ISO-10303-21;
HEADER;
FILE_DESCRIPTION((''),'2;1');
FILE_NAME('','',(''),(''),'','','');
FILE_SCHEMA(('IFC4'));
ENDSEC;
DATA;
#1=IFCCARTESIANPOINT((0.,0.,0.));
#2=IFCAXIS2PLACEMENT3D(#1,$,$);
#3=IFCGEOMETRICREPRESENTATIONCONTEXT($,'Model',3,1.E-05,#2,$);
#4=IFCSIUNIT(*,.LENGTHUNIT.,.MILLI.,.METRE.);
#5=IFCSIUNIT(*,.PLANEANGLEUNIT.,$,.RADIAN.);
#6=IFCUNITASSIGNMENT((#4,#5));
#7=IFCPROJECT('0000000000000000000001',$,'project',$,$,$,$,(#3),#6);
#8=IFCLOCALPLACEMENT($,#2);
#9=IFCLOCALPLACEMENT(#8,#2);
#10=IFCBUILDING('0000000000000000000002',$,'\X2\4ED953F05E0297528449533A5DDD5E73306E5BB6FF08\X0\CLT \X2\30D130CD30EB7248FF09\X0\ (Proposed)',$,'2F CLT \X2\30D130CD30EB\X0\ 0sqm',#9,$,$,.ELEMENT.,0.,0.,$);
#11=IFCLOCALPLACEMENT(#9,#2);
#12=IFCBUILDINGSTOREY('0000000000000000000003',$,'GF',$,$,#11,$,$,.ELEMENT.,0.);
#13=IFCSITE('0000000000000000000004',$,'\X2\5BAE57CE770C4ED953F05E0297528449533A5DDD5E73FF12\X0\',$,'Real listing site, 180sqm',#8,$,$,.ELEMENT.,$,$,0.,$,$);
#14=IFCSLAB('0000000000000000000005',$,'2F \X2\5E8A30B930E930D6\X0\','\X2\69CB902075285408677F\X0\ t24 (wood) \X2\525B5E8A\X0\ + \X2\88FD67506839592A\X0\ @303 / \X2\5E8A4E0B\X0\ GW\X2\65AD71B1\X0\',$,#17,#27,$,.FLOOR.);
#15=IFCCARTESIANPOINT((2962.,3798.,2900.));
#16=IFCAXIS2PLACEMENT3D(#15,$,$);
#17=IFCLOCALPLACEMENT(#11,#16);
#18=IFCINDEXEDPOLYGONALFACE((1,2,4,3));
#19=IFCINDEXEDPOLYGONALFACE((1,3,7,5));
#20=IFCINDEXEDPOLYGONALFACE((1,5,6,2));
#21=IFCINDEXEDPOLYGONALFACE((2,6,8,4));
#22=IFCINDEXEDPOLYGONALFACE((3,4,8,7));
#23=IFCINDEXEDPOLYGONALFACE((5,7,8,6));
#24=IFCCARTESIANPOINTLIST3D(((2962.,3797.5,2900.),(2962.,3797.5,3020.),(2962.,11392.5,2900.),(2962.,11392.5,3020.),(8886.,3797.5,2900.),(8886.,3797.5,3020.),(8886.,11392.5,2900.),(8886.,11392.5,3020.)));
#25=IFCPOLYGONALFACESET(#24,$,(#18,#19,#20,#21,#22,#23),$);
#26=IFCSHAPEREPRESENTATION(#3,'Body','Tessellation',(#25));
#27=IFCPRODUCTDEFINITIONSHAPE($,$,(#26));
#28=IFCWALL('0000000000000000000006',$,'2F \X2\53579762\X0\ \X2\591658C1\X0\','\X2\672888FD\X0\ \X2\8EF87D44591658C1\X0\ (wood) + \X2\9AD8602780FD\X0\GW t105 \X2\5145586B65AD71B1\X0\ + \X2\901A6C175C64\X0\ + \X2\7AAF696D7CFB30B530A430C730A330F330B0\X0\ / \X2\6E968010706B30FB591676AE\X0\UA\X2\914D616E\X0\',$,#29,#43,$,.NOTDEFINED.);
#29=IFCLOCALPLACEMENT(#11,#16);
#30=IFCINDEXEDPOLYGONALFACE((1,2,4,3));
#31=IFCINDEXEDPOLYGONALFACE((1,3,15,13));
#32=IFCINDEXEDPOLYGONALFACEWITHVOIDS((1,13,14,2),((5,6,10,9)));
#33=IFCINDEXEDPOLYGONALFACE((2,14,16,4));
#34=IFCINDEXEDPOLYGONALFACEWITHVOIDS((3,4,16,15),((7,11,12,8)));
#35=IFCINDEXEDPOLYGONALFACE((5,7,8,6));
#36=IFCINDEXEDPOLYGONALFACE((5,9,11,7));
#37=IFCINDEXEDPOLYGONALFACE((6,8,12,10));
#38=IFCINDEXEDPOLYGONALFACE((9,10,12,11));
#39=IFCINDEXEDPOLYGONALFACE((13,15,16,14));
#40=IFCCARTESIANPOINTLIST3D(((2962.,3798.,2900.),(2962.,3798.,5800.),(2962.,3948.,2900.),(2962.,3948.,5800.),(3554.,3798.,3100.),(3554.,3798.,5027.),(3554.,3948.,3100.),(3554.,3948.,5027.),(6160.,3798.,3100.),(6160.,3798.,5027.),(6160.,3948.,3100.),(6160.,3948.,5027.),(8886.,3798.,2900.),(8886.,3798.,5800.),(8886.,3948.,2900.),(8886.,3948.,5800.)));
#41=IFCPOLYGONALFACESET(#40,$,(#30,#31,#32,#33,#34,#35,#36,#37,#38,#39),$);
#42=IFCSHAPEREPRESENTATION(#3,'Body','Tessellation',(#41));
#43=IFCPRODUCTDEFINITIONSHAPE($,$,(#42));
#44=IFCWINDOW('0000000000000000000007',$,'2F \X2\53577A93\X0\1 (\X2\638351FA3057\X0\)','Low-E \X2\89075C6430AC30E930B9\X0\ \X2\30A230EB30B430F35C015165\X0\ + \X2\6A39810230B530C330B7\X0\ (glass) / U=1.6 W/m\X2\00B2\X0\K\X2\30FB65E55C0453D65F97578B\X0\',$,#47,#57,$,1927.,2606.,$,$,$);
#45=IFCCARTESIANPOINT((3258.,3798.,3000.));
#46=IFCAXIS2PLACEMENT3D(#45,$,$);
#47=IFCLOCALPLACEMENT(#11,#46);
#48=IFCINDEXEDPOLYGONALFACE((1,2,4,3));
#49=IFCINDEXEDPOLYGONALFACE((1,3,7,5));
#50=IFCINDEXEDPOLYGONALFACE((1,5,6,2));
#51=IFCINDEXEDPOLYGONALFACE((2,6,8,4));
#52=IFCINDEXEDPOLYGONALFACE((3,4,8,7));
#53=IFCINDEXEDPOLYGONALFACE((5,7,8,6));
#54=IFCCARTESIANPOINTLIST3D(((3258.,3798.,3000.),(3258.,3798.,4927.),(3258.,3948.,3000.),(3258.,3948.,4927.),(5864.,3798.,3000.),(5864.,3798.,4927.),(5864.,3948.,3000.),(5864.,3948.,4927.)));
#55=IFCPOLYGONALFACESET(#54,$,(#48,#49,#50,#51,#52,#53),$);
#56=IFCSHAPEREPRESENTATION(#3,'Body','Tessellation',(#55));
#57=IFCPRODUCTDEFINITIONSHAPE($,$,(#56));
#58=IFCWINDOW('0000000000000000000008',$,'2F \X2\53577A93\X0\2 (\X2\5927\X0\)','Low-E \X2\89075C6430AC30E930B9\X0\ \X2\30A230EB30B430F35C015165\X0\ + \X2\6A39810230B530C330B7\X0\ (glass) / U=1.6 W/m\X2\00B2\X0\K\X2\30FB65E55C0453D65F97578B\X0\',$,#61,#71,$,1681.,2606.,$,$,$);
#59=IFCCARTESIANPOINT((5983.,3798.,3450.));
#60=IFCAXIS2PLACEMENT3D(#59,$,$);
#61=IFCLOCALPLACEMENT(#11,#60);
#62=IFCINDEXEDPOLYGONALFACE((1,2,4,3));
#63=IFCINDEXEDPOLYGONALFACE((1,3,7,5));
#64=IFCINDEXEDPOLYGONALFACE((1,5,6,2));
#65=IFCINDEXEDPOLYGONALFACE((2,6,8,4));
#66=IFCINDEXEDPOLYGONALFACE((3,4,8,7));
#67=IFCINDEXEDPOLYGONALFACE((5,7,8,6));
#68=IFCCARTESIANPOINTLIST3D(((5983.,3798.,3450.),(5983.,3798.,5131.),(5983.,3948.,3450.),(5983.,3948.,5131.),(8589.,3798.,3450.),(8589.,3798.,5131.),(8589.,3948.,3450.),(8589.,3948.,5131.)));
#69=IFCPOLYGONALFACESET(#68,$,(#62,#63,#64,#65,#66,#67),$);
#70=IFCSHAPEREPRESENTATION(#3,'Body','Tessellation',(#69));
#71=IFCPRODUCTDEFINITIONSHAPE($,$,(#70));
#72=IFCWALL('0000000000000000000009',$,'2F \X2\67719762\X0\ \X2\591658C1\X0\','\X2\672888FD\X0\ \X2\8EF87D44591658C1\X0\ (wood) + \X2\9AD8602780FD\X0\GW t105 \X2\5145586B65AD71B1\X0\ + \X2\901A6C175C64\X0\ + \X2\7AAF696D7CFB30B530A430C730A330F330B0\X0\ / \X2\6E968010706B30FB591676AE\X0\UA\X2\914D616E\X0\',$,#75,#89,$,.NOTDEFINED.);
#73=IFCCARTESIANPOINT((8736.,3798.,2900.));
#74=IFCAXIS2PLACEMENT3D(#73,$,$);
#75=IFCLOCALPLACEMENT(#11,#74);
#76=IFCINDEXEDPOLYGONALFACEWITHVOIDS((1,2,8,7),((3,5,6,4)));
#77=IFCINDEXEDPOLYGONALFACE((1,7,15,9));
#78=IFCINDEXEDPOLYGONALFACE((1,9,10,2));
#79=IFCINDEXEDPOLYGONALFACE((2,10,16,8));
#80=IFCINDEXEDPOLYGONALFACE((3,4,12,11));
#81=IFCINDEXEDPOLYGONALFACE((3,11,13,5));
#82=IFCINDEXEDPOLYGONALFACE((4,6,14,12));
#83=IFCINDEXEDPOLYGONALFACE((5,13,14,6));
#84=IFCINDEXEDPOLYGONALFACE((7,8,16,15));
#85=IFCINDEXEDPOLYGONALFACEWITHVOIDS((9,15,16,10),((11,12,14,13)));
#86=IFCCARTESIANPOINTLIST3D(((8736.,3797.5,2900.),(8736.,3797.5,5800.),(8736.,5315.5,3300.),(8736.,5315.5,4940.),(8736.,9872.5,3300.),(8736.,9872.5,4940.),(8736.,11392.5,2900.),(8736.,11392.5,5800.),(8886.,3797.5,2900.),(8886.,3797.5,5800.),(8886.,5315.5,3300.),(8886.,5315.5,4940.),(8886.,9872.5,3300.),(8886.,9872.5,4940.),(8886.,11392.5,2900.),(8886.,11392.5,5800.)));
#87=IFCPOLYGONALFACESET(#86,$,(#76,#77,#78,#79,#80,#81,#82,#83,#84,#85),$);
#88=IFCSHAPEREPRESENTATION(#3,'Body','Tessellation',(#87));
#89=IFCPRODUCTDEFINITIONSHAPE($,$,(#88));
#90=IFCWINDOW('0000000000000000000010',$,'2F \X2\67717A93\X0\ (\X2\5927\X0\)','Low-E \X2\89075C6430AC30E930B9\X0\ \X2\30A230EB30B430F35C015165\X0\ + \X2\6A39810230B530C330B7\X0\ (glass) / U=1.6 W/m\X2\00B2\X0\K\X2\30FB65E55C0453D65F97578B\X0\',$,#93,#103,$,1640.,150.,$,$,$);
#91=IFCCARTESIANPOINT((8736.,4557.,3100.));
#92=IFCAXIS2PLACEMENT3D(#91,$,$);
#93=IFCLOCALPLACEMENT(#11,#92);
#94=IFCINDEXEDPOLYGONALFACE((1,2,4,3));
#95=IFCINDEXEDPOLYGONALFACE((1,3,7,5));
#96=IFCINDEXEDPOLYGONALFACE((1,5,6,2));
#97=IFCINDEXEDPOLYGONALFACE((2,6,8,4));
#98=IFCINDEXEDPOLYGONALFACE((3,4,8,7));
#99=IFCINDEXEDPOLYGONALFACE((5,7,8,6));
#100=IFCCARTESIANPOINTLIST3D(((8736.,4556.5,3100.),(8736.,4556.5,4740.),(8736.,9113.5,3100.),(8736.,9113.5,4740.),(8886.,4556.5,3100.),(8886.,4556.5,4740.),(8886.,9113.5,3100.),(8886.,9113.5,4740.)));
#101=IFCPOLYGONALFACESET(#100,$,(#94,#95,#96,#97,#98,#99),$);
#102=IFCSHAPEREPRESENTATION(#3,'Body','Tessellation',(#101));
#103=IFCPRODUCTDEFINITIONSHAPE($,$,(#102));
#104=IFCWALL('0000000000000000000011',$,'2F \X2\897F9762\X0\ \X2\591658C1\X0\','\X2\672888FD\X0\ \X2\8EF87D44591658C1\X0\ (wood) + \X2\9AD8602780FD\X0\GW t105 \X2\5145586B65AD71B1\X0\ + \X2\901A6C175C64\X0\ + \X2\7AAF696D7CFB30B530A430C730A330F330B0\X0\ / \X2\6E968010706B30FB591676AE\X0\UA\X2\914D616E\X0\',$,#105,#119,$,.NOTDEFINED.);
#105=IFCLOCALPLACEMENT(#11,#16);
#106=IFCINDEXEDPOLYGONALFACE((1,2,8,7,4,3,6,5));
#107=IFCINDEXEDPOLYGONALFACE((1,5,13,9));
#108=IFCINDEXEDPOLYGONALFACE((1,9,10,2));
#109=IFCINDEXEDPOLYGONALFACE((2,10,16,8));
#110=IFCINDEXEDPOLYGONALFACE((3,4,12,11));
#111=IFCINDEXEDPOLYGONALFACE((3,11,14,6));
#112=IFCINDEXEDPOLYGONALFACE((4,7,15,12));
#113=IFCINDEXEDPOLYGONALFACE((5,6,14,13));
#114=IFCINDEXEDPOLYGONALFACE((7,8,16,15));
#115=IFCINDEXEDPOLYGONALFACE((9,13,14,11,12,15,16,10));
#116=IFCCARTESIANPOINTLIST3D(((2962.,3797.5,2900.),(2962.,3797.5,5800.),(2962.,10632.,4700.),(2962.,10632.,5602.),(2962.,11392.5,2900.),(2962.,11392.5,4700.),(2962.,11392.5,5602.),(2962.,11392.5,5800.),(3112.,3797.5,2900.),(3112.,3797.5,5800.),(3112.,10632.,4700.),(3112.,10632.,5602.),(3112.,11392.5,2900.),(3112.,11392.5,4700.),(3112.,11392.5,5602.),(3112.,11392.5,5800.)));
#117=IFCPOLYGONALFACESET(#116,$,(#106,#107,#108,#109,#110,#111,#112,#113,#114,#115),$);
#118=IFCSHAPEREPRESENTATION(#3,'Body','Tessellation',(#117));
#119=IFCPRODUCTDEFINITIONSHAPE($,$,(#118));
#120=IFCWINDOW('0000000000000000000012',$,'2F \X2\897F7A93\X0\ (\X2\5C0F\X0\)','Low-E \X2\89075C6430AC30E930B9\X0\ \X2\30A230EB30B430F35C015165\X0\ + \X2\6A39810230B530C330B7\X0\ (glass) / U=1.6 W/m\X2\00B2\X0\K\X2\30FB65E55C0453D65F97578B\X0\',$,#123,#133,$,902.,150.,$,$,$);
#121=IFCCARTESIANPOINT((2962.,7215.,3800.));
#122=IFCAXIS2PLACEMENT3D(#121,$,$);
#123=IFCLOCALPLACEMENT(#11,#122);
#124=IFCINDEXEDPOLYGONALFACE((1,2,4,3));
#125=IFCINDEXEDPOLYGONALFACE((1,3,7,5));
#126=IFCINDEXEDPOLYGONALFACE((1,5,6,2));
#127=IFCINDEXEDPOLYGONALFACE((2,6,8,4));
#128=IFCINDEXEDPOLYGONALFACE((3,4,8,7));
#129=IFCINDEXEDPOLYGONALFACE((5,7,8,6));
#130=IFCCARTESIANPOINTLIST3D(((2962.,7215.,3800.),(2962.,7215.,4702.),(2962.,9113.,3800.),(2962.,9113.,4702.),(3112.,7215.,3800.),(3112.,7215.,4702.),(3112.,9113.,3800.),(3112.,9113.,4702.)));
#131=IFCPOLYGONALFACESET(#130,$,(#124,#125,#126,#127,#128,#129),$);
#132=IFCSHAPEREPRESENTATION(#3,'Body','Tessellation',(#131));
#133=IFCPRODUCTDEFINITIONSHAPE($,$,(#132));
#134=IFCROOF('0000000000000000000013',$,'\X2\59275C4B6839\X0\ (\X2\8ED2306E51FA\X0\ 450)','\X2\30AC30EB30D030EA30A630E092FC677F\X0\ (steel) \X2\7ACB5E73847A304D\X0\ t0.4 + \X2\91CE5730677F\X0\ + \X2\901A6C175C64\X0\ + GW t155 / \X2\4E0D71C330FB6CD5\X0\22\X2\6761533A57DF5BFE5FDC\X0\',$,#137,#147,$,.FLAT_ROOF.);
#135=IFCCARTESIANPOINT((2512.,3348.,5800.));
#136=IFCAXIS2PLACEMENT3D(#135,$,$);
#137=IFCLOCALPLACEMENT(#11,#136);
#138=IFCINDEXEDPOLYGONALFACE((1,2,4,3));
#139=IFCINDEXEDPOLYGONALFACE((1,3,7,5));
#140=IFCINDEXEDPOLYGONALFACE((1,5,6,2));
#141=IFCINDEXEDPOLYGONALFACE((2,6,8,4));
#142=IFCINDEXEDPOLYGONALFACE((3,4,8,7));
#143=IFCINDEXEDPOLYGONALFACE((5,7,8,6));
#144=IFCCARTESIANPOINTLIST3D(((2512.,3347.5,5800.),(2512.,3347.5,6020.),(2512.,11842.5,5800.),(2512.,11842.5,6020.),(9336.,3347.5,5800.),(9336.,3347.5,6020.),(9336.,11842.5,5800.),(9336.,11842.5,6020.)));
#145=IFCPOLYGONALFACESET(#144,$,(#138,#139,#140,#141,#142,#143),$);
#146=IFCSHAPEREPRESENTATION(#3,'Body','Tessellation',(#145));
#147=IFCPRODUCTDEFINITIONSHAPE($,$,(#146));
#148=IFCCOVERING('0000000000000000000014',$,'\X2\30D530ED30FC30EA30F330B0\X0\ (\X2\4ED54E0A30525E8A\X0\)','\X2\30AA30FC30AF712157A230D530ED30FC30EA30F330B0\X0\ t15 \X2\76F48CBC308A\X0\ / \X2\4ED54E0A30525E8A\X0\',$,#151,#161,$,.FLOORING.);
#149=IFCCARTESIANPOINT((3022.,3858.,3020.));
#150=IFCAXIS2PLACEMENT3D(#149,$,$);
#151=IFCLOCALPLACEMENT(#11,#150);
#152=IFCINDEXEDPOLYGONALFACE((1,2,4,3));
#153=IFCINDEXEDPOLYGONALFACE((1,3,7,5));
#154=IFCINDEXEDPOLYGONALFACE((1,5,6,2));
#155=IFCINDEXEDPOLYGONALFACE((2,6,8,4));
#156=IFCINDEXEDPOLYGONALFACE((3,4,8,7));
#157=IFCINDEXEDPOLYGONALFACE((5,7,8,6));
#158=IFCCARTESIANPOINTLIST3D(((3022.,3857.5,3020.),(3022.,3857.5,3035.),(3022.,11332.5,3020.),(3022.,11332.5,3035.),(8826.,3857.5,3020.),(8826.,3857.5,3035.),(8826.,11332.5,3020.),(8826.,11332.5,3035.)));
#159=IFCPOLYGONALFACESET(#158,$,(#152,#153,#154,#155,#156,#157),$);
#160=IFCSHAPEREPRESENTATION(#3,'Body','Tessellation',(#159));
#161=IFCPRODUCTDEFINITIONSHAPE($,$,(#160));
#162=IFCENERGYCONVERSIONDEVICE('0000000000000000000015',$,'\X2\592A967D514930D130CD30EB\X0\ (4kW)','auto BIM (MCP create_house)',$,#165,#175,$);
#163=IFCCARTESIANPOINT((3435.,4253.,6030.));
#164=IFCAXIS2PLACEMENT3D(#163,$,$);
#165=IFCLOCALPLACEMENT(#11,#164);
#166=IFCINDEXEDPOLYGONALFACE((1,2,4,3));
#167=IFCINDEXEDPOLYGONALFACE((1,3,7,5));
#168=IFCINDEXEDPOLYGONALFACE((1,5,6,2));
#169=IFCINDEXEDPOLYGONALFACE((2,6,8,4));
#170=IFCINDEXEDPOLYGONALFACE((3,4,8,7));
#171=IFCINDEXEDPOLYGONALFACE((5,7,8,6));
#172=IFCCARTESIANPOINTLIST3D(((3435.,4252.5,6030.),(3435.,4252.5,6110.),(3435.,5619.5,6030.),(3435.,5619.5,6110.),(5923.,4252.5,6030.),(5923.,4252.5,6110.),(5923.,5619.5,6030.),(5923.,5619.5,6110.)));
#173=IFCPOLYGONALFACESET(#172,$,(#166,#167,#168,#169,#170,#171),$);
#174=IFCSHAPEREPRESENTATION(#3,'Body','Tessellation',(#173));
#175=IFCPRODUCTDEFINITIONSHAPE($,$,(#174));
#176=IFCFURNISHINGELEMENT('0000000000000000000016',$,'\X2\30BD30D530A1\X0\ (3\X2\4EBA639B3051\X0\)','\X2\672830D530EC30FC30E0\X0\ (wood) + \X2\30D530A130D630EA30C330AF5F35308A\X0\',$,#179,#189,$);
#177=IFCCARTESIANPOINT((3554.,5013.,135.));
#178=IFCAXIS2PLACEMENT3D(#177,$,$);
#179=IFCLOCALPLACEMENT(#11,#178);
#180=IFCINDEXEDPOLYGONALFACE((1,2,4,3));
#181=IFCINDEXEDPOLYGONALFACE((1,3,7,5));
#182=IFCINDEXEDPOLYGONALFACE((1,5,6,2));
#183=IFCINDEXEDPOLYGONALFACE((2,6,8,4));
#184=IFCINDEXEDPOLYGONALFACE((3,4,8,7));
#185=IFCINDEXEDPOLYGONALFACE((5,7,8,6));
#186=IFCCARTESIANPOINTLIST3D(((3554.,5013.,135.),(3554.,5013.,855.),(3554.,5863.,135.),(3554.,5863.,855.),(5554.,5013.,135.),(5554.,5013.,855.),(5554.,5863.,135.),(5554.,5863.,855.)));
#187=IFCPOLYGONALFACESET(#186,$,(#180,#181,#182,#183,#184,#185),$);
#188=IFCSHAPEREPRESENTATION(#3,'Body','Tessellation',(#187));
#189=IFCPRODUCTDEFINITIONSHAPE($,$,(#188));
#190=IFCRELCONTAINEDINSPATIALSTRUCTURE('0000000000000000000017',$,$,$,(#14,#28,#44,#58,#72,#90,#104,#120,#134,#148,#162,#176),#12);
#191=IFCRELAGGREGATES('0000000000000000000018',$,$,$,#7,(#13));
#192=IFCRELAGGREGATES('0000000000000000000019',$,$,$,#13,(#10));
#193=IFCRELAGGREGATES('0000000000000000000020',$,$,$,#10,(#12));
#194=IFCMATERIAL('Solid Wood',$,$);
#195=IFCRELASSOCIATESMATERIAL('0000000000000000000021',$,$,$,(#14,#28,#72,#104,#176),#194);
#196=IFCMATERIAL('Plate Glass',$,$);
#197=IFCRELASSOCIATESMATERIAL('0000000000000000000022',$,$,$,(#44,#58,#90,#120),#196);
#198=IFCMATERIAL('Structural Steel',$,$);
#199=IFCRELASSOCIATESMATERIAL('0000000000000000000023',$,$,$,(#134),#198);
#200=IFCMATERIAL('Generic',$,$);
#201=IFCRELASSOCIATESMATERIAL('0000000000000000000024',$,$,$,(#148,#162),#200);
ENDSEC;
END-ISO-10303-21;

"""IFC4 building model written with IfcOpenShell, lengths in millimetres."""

from ifc_helpers import new_model, si_unit, frame, frame_2d, origin, place, context, project, spatial, rectangle, extrude, material, element, fill, save


model = new_model("IFC4")

# Units and contexts
model_context = context("Model", 3, precision=1e-05, world=origin())
ifc_project = project(units=[si_unit("LENGTHUNIT", "METRE", prefix="MILLI"), si_unit("PLANEANGLEUNIT", "RADIAN")], contexts=[model_context])

# Site, building, storey
site_placement = place(None, origin())
site = spatial("IfcSite", under=ifc_project, at=site_placement, Name="宮城県仙台市青葉区川平２", ObjectType="Real listing site, 180sqm", CompositionType="ELEMENT", RefElevation=0.0)
building_placement = place(site_placement, origin())
building = spatial("IfcBuilding", under=site, at=building_placement, Name="仙台市青葉区川平の家（CLT パネル版） (Proposed)", ObjectType="2F CLT パネル 0sqm", CompositionType="ELEMENT", ElevationOfRefHeight=0.0, ElevationOfTerrain=0.0)
storey_placement = place(building_placement, origin())
storey = spatial("IfcBuildingStorey", under=building, at=storey_placement, Name="GF", CompositionType="ELEMENT", Elevation=0.0)

# Slab
ifc_material_1 = material(Name="Solid Wood")
slab_placement = place(storey_placement, frame((2962.0, 3798.0, 2900.0)))
element("IfcSlab", 1, at=slab_placement, inside=storey, material=ifc_material_1, Name="2F 床スラブ", Description="構造用合板 t24 (wood) 剛床 + 製材根太 @303 / 床下 GW断熱", PredefinedType="FLOOR", context=model_context, shape_type="SweptSolid", body=[
    extrude(rectangle(XDim=5924.0, YDim=7595.0, at=frame_2d((2962.0, 3797.0))), frame((2962.0, 3798.0, 2900.0)), (0.0, 0.0, 1.0), 120.0),
])

# Wall, openings, windows
wall_1_placement = place(storey_placement, frame((2962.0, 3798.0, 2900.0)))
wall_1 = element("IfcWall", 2, at=wall_1_placement, inside=storey, material=ifc_material_1, Name="2F 南面 外壁", Description="木製 軸組外壁 (wood) + 高性能GW t105 充填断熱 + 通気層 + 窯業系サイディング / 準耐火・外皮UA配慮", PredefinedType="NOTDEFINED", context=model_context, shape_type="SweptSolid", body=[
    extrude(rectangle(XDim=5924.0, YDim=150.0, at=frame_2d((2962.0, 75.0))), frame((2962.0, 3798.0, 2900.0)), (0.0, 0.0, 1.0), 2900.0),
])
opening_1_placement = place(storey_placement, frame((3258.0, 3798.0, 3000.0)))
opening_1 = element("IfcOpeningElement", 3, at=opening_1_placement, cuts=wall_1, PredefinedType="NOTDEFINED", context=model_context, shape_type="SweptSolid", body=[
    extrude(rectangle(XDim=2606.0, YDim=150.0, at=frame_2d((1303.0, 75.0))), frame((3258.0, 3798.0, 3000.0)), (0.0, 0.0, 1.0), 1927.0),
])
opening_2_placement = place(storey_placement, frame((5983.0, 3798.0, 3450.0)))
opening_2 = element("IfcOpeningElement", 4, at=opening_2_placement, cuts=wall_1, PredefinedType="NOTDEFINED", context=model_context, shape_type="SweptSolid", body=[
    extrude(rectangle(XDim=2606.0, YDim=150.0, at=frame_2d((1303.0, 75.0))), frame((5983.0, 3798.0, 3450.0)), (0.0, 0.0, 1.0), 1681.0),
])
ifc_material_2 = material(Name="Plate Glass")
window_1_placement = place(storey_placement, frame((3258.0, 3798.0, 3000.0)))
window_1 = element("IfcWindow", 5, at=window_1_placement, inside=storey, material=ifc_material_2, Name="2F 南窓1 (掃出し)", Description="Low-E 複層ガラス アルゴン封入 + 樹脂サッシ (glass) / U=1.6 W/m²K・日射取得型", OverallHeight=1927.0, OverallWidth=2606.0, context=model_context, shape_type="SweptSolid", body=[
    extrude(rectangle(XDim=2606.0, YDim=150.0, at=frame_2d((1303.0, 75.0))), frame((3258.0, 3798.0, 3000.0)), (0.0, 0.0, 1.0), 1927.0),
])
fill(opening_1, window_1)
window_2_placement = place(storey_placement, frame((5983.0, 3798.0, 3450.0)))
window_2 = element("IfcWindow", 6, at=window_2_placement, inside=storey, material=ifc_material_2, Name="2F 南窓2 (大)", Description="Low-E 複層ガラス アルゴン封入 + 樹脂サッシ (glass) / U=1.6 W/m²K・日射取得型", OverallHeight=1681.0, OverallWidth=2606.0, context=model_context, shape_type="SweptSolid", body=[
    extrude(rectangle(XDim=2606.0, YDim=150.0, at=frame_2d((1303.0, 75.0))), frame((5983.0, 3798.0, 3450.0)), (0.0, 0.0, 1.0), 1681.0),
])
fill(opening_2, window_2)

# Walls, openings, windows
wall_2_placement = place(storey_placement, frame((8736.0, 3798.0, 2900.0)))
wall_2 = element("IfcWall", 7, at=wall_2_placement, inside=storey, material=ifc_material_1, Name="2F 東面 外壁", Description="木製 軸組外壁 (wood) + 高性能GW t105 充填断熱 + 通気層 + 窯業系サイディング / 準耐火・外皮UA配慮", PredefinedType="NOTDEFINED", context=model_context, shape_type="SweptSolid", body=[
    extrude(rectangle(XDim=150.0, YDim=7595.0, at=frame_2d((75.0, 3797.0))), frame((8736.0, 3798.0, 2900.0)), (0.0, 0.0, 1.0), 2900.0),
])
opening_3_placement = place(storey_placement, frame((8736.0, 4557.0, 3100.0)))
opening_3 = element("IfcOpeningElement", 8, at=opening_3_placement, cuts=wall_2, PredefinedType="NOTDEFINED", context=model_context, shape_type="SweptSolid", body=[
    extrude(rectangle(XDim=150.0, YDim=4557.0, at=frame_2d((75.0, 2278.0))), frame((8736.0, 4557.0, 3100.0)), (0.0, 0.0, 1.0), 1640.0),
])
window_3_placement = place(storey_placement, frame((8736.0, 4557.0, 3100.0)))
window_3 = element("IfcWindow", 9, at=window_3_placement, inside=storey, material=ifc_material_2, Name="2F 東窓 (大)", Description="Low-E 複層ガラス アルゴン封入 + 樹脂サッシ (glass) / U=1.6 W/m²K・日射取得型", OverallHeight=1640.0, OverallWidth=150.0, context=model_context, shape_type="SweptSolid", body=[
    extrude(rectangle(XDim=150.0, YDim=4557.0, at=frame_2d((75.0, 2278.0))), frame((8736.0, 4557.0, 3100.0)), (0.0, 0.0, 1.0), 1640.0),
])
fill(opening_3, window_3)
wall_3_placement = place(storey_placement, frame((2962.0, 3798.0, 2900.0)))
wall_3 = element("IfcWall", 10, at=wall_3_placement, inside=storey, material=ifc_material_1, Name="2F 西面 外壁", Description="木製 軸組外壁 (wood) + 高性能GW t105 充填断熱 + 通気層 + 窯業系サイディング / 準耐火・外皮UA配慮", PredefinedType="NOTDEFINED", context=model_context, shape_type="SweptSolid", body=[
    extrude(rectangle(XDim=150.0, YDim=7595.0, at=frame_2d((75.0, 3797.0))), frame((2962.0, 3798.0, 2900.0)), (0.0, 0.0, 1.0), 2900.0),
])
opening_4_placement = place(storey_placement, frame((2962.0, 7215.0, 3800.0)))
opening_4 = element("IfcOpeningElement", 11, at=opening_4_placement, cuts=wall_3, PredefinedType="NOTDEFINED", context=model_context, shape_type="SweptSolid", body=[
    extrude(rectangle(XDim=150.0, YDim=1898.0, at=frame_2d((75.0, 949.0))), frame((2962.0, 7215.0, 3800.0)), (0.0, 0.0, 1.0), 902.0),
])
window_4_placement = place(storey_placement, frame((2962.0, 7215.0, 3800.0)))
window_4 = element("IfcWindow", 12, at=window_4_placement, inside=storey, material=ifc_material_2, Name="2F 西窓 (小)", Description="Low-E 複層ガラス アルゴン封入 + 樹脂サッシ (glass) / U=1.6 W/m²K・日射取得型", OverallHeight=902.0, OverallWidth=150.0, context=model_context, shape_type="SweptSolid", body=[
    extrude(rectangle(XDim=150.0, YDim=1898.0, at=frame_2d((75.0, 949.0))), frame((2962.0, 7215.0, 3800.0)), (0.0, 0.0, 1.0), 902.0),
])
fill(opening_4, window_4)

# Roof
ifc_material_3 = material(Name="Structural Steel")
roof_placement = place(storey_placement, frame((2512.0, 3348.0, 5800.0)))
element("IfcRoof", 13, at=roof_placement, inside=storey, material=ifc_material_3, Name="大屋根 (軒の出 450)", Description="ガルバリウム鋼板 (steel) 立平葺き t0.4 + 野地板 + 通気層 + GW t155 / 不燃・法22条区域対応", PredefinedType="FLAT_ROOF", context=model_context, shape_type="SweptSolid", body=[
    extrude(rectangle(XDim=6824.0, YDim=8495.0, at=frame_2d((3412.0, 4247.0))), frame((2512.0, 3348.0, 5800.0)), (0.0, 0.0, 1.0), 220.0),
])

# Covering
ifc_material_4 = material(Name="Generic")
covering_placement = place(storey_placement, frame((3022.0, 3858.0, 3020.0)))
element("IfcCovering", 14, at=covering_placement, inside=storey, material=ifc_material_4, Name="フローリング (仕上げ床)", Description="オーク無垢フローリング t15 直貼り / 仕上げ床", PredefinedType="FLOORING", context=model_context, shape_type="SweptSolid", body=[
    extrude(rectangle(XDim=5804.0, YDim=7475.0, at=frame_2d((2902.0, 3737.0))), frame((3022.0, 3858.0, 3020.0)), (0.0, 0.0, 1.0), 15.0),
])

# Energy conversion device
energy_conversion_device_placement = place(storey_placement, frame((3435.0, 4253.0, 6030.0)))
element("IfcEnergyConversionDevice", 15, at=energy_conversion_device_placement, inside=storey, material=ifc_material_4, Name="太陽光パネル (4kW)", Description="auto BIM (MCP create_house)", context=model_context, shape_type="SweptSolid", body=[
    extrude(rectangle(XDim=2488.0, YDim=1367.0, at=frame_2d((1244.0, 683.0))), frame((3435.0, 4253.0, 6030.0)), (0.0, 0.0, 1.0), 80.0),
])

# Furnishing element
furnishing_1_placement = place(storey_placement, frame((3554.0, 5013.0, 135.0)))
element("IfcFurnishingElement", 16, at=furnishing_1_placement, inside=storey, material=ifc_material_1, Name="ソファ (3人掛け)", Description="木フレーム (wood) + ファブリック張り", context=model_context, shape_type="SweptSolid", body=[
    extrude(rectangle(XDim=2000.0, YDim=850.0, at=frame_2d((1000.0, 425.0))), frame((3554.0, 5013.0, 135.0)), (0.0, 0.0, 1.0), 720.0),
])

save(model, "model.ifc")
